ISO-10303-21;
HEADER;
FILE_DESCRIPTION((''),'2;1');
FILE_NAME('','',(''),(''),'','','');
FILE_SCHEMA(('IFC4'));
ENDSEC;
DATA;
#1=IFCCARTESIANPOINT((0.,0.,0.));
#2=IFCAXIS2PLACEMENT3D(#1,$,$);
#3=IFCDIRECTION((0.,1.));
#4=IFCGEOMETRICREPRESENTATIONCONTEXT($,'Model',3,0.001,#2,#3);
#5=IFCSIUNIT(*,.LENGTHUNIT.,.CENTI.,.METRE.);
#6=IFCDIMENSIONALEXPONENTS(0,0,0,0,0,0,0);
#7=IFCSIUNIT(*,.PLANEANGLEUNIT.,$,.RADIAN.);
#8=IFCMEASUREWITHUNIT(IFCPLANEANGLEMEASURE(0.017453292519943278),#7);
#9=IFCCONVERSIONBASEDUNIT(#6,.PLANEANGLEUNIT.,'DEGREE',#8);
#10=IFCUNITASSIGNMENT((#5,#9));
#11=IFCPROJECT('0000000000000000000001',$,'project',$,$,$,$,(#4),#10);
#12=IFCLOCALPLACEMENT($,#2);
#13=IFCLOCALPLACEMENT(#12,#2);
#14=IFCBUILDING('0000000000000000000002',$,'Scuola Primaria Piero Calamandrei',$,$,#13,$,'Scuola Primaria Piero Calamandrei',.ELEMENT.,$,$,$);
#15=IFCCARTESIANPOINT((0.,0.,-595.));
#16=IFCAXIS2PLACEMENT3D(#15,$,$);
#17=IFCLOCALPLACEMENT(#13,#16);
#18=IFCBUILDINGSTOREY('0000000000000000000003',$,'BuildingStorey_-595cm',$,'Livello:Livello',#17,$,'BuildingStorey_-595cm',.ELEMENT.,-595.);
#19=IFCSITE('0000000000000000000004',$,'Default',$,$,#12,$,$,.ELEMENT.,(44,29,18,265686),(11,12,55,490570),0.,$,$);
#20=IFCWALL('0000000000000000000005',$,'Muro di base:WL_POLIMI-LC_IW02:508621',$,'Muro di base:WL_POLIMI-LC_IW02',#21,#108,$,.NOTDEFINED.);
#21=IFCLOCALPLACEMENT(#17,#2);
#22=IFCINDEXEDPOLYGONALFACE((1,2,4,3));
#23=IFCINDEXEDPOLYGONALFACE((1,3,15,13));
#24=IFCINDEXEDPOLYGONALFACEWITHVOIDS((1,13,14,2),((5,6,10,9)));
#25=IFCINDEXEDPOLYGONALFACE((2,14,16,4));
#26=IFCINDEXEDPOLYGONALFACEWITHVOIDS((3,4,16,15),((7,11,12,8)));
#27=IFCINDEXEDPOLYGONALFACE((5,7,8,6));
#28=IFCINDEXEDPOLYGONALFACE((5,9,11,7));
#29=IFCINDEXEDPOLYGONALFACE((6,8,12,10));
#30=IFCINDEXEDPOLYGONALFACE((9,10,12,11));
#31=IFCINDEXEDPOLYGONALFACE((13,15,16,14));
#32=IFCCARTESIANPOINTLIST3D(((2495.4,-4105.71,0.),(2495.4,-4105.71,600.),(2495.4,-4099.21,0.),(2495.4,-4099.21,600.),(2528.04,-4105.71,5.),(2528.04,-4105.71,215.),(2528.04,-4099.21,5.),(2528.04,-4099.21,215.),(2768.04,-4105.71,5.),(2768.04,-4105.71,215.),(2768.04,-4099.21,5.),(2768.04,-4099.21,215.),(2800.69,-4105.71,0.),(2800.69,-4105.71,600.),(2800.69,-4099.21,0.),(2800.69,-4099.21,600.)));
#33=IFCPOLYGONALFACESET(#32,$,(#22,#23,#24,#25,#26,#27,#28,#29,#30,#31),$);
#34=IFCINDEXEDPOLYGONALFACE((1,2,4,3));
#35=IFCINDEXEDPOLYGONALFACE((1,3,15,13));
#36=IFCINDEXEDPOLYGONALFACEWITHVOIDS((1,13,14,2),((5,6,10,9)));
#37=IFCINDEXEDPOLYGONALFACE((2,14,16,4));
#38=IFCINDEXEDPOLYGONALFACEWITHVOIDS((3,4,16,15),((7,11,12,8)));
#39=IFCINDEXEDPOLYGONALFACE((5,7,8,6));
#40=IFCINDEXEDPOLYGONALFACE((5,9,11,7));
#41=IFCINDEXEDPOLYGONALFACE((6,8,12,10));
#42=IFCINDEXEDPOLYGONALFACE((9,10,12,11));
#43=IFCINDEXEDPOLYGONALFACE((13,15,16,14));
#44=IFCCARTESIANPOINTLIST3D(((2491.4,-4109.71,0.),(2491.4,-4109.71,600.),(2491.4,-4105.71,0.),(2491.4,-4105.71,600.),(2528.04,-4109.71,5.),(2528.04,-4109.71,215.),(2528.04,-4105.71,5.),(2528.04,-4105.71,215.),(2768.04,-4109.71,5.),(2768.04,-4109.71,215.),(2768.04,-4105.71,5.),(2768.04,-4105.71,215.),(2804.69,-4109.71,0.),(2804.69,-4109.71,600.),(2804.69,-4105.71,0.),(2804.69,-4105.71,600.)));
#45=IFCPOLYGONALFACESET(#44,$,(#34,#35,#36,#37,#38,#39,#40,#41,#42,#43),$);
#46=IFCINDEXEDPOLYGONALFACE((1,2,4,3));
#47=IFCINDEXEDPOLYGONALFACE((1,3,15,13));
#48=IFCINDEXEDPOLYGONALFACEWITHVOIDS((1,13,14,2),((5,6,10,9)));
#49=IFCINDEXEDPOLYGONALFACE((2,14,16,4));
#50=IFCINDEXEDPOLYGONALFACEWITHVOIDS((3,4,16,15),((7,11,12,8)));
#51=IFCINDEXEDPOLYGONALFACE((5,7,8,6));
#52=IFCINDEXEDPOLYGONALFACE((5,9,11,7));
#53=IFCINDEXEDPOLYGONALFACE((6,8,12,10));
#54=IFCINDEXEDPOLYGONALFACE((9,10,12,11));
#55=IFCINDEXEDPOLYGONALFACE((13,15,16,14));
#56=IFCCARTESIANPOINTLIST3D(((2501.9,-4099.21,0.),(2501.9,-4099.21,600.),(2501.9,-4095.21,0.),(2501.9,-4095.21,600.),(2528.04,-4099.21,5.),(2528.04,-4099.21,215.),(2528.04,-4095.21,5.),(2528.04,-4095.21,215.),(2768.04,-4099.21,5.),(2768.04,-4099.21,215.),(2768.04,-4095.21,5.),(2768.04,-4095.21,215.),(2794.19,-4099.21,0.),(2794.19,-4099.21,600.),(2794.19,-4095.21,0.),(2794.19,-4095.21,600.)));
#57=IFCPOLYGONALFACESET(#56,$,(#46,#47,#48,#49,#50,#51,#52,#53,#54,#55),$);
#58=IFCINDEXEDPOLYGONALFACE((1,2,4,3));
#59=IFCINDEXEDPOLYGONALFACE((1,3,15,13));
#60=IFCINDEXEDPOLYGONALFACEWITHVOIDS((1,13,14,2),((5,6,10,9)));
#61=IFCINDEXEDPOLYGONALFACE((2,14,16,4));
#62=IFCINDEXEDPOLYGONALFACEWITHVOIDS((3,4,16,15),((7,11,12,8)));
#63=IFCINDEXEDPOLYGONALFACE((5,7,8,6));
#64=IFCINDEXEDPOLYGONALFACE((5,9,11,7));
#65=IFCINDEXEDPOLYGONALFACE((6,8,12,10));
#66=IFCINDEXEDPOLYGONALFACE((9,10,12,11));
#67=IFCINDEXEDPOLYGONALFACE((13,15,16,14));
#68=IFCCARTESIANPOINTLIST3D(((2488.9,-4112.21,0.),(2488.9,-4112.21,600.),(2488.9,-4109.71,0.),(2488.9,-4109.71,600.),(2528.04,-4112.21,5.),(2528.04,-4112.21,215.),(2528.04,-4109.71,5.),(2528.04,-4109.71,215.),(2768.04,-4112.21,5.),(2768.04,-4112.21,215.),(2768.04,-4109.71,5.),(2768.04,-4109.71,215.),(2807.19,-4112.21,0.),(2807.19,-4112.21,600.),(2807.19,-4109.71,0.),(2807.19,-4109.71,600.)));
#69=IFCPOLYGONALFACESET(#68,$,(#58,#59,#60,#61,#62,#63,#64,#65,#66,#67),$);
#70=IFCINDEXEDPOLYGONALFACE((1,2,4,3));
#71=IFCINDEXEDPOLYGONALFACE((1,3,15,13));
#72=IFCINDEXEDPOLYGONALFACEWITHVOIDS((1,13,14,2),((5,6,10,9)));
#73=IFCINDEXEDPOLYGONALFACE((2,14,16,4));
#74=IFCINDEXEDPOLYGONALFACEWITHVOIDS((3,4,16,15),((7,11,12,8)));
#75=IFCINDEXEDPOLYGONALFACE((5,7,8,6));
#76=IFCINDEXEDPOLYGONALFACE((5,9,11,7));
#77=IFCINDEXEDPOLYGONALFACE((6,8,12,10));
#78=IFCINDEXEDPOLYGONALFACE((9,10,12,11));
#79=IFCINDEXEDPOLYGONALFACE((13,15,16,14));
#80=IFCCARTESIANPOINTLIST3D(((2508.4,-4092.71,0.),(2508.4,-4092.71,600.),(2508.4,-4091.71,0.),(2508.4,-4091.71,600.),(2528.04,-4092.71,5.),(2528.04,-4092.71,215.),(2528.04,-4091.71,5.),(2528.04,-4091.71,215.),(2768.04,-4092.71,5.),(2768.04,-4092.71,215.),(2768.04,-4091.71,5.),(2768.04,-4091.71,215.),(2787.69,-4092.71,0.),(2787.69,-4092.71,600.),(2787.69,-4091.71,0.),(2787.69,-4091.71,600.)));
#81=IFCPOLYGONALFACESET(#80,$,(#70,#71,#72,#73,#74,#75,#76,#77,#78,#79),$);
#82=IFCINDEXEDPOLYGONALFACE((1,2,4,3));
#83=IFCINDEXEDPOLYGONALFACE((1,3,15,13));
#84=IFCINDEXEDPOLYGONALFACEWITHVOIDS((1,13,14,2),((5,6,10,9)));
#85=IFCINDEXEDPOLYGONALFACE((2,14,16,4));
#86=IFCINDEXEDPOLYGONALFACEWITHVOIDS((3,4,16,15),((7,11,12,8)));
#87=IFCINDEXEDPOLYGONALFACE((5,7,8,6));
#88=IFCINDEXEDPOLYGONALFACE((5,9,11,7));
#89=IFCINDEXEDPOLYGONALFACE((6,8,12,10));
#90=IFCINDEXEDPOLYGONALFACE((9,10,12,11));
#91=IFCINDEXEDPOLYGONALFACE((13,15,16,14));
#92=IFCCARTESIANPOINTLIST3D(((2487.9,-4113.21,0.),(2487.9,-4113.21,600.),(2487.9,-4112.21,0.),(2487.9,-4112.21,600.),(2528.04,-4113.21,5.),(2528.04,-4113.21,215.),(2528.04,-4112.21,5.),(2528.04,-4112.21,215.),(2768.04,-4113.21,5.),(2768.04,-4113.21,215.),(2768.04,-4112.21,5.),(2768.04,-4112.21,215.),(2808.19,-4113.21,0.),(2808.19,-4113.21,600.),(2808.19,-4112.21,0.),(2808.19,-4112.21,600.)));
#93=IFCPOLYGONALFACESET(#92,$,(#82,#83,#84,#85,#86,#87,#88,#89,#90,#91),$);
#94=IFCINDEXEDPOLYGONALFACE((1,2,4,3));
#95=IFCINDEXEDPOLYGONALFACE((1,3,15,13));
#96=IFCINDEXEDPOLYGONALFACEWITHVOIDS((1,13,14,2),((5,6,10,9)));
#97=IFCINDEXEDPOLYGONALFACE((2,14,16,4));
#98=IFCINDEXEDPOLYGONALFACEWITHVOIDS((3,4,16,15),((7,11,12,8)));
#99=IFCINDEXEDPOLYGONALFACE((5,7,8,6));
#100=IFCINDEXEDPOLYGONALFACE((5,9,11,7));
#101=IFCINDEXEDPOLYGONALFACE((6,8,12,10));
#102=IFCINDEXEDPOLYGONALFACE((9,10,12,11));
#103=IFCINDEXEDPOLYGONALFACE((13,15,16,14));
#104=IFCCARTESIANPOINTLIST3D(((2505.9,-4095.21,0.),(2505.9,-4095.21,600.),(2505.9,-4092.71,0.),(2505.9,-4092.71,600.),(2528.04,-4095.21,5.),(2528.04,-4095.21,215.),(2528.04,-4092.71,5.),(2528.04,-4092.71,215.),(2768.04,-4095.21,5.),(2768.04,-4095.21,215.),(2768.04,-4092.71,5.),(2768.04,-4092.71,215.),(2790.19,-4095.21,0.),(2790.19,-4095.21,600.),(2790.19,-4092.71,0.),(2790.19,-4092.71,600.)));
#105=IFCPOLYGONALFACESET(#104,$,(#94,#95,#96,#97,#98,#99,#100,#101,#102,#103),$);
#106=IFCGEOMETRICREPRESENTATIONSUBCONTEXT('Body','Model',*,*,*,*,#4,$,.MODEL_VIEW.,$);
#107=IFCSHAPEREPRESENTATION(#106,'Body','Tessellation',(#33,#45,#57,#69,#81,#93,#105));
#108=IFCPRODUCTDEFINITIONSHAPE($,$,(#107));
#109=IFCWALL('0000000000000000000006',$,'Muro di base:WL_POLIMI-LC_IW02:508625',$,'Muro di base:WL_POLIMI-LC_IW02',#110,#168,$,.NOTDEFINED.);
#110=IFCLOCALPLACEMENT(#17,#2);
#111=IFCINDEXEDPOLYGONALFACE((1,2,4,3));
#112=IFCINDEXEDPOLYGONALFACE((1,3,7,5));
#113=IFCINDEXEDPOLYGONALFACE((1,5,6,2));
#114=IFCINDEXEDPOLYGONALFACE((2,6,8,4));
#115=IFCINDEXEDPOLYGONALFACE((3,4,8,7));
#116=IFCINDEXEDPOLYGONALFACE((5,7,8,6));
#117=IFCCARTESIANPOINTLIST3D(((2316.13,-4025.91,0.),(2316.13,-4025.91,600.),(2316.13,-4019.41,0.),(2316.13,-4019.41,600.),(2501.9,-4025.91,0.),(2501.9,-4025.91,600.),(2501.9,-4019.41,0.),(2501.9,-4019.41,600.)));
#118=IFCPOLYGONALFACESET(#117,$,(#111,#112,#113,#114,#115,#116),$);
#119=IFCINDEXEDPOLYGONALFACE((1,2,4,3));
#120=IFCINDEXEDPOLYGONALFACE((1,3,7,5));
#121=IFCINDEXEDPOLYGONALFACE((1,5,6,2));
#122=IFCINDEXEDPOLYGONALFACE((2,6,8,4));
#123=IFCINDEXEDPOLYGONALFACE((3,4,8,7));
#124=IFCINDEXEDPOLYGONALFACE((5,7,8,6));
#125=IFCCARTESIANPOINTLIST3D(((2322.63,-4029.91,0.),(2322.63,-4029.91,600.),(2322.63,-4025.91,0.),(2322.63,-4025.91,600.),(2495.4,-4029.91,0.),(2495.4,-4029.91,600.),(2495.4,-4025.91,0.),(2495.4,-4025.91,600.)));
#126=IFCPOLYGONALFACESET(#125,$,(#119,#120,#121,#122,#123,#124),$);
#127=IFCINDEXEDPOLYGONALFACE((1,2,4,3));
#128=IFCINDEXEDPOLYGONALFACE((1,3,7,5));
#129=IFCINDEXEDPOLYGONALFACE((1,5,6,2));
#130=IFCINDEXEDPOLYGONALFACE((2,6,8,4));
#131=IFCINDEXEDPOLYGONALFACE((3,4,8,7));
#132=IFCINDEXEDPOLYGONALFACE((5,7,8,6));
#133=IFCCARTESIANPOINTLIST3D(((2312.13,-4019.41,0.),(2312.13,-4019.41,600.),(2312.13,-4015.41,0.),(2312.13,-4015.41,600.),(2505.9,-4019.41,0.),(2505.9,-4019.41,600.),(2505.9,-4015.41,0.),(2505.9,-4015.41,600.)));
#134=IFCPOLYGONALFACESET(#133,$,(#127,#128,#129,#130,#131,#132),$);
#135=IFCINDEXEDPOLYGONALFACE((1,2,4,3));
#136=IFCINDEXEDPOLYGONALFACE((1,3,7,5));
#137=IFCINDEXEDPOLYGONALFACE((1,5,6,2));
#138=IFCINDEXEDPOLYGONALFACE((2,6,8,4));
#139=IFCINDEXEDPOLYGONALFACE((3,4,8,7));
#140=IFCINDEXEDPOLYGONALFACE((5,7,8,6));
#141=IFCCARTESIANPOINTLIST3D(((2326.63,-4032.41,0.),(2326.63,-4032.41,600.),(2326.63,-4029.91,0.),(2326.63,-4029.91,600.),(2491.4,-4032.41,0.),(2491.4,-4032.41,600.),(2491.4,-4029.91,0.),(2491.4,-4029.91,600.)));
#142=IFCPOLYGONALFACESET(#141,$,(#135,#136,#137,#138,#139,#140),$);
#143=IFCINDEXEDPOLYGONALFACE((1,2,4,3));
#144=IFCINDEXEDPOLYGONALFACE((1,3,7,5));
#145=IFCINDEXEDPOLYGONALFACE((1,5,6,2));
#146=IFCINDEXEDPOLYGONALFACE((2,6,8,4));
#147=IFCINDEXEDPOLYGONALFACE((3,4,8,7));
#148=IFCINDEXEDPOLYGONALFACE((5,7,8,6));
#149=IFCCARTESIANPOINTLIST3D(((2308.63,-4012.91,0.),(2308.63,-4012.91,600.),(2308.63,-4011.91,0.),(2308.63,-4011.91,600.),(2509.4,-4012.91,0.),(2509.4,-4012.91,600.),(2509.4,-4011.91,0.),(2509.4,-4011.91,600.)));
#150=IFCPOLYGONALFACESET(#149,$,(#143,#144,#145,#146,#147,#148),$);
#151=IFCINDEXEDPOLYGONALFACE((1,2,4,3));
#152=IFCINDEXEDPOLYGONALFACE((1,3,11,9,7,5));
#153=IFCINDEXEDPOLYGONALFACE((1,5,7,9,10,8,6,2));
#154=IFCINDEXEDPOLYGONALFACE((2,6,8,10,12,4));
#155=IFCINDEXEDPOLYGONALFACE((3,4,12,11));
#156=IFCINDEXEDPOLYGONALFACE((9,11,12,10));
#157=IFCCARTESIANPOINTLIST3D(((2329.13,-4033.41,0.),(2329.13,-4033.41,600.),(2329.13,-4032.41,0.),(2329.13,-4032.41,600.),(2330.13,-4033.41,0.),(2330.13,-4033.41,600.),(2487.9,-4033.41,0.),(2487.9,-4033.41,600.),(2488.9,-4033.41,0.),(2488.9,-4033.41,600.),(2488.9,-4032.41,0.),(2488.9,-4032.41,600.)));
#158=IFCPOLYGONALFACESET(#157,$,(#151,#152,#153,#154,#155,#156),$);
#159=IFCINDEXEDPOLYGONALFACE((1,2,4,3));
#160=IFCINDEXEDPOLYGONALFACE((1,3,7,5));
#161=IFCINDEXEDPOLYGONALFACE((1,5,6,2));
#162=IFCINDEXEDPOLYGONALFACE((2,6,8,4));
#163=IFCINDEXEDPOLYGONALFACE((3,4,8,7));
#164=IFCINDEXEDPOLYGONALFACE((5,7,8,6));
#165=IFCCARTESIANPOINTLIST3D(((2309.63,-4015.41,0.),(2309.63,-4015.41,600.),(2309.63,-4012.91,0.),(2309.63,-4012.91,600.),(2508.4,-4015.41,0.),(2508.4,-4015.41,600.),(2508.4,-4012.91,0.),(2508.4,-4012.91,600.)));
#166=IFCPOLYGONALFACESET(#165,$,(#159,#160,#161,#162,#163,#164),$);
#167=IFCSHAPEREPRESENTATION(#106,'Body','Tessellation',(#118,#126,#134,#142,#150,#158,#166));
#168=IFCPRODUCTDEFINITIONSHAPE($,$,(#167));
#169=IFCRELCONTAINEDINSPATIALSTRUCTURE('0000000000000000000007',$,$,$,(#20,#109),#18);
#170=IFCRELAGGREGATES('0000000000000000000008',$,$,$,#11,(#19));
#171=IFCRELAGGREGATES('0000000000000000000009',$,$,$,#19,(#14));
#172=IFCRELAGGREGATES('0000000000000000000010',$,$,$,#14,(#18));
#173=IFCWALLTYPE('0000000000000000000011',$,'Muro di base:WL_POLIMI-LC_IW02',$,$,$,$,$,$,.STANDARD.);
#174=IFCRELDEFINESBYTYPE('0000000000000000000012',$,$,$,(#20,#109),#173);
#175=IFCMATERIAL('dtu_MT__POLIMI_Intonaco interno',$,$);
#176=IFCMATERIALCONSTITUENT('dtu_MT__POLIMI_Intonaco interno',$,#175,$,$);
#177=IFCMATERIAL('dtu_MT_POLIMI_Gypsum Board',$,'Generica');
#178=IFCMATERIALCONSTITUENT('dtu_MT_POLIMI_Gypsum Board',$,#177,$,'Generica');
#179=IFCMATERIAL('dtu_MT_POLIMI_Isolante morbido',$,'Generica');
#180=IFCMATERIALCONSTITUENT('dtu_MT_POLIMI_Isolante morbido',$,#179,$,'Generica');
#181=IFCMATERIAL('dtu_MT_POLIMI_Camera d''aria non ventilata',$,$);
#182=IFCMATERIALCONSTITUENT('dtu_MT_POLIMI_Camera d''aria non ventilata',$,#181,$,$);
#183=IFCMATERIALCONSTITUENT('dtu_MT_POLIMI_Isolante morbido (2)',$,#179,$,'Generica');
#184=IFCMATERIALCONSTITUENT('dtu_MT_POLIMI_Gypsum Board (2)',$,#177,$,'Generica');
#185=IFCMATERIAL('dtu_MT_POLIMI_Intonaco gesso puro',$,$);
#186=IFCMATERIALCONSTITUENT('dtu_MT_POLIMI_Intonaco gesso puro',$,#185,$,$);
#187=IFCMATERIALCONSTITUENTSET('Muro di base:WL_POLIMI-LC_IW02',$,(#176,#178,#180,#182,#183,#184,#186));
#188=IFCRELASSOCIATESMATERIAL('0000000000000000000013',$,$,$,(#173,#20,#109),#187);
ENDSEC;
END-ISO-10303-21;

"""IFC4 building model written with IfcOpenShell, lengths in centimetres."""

from ifc_helpers import new_model, entity, si_unit, converted_unit, direction, frame, origin, place, context, subcontext, project, spatial, indexed_curve, outline, extrude, material, constituent, constituent_set, type_object, element, save


model = new_model("IFC4")

# Units and contexts
model_context = context("Model", 3, precision=0.001, world=origin(), true_north=direction((0.0, 1.0)))
body_context = subcontext(model_context, "Body", "Model", "MODEL_VIEW")
ifc_project = project(units=[si_unit("LENGTHUNIT", "METRE", prefix="CENTI"), converted_unit("PLANEANGLEUNIT", "DEGREE", entity("IfcPlaneAngleMeasure", 0.017453292519943278), si_unit("PLANEANGLEUNIT", "RADIAN"), dimensions=[0, 0, 0, 0, 0, 0, 0])], contexts=[model_context])

# Site, building, storey
site_placement = place(None, origin())
site = spatial("IfcSite", under=ifc_project, at=site_placement, Name="Default", CompositionType="ELEMENT", RefLatitude=(44, 29, 18, 265686), RefLongitude=(11, 12, 55, 490570), RefElevation=0.0)
building_placement = place(site_placement, origin())
building = spatial("IfcBuilding", under=site, at=building_placement, Name="Scuola Primaria Piero Calamandrei", LongName="Scuola Primaria Piero Calamandrei", CompositionType="ELEMENT")
storey_placement = place(building_placement, frame((0.0, 0.0, -595.0)))
storey = spatial("IfcBuildingStorey", under=building, at=storey_placement, Name="BuildingStorey_-595cm", ObjectType="Livello:Livello", LongName="BuildingStorey_-595cm", CompositionType="ELEMENT", Elevation=-595.0)

# Shared definitions
ifc_material_1 = material(Name="dtu_MT__POLIMI_Intonaco interno")
ifc_constituent_1 = constituent(ifc_material_1, Name="dtu_MT__POLIMI_Intonaco interno")
ifc_material_2 = material(Name="dtu_MT_POLIMI_Gypsum Board", Category="Generica")
ifc_constituent_2 = constituent(ifc_material_2, Name="dtu_MT_POLIMI_Gypsum Board", Category="Generica")
ifc_material_3 = material(Name="dtu_MT_POLIMI_Isolante morbido", Category="Generica")
ifc_constituent_3 = constituent(ifc_material_3, Name="dtu_MT_POLIMI_Isolante morbido", Category="Generica")
ifc_material_4 = material(Name="dtu_MT_POLIMI_Camera d'aria non ventilata")
ifc_constituent_4 = constituent(ifc_material_4, Name="dtu_MT_POLIMI_Camera d'aria non ventilata")
ifc_constituent_5 = constituent(ifc_material_3, Name="dtu_MT_POLIMI_Isolante morbido (2)", Category="Generica")
ifc_constituent_6 = constituent(ifc_material_2, Name="dtu_MT_POLIMI_Gypsum Board (2)", Category="Generica")
ifc_material_5 = material(Name="dtu_MT_POLIMI_Intonaco gesso puro")
ifc_constituent_7 = constituent(ifc_material_5, Name="dtu_MT_POLIMI_Intonaco gesso puro")
ifc_constituent_set_1 = constituent_set(constituents=[ifc_constituent_1, ifc_constituent_2, ifc_constituent_3, ifc_constituent_4, ifc_constituent_5, ifc_constituent_6, ifc_constituent_7], Name="Muro di base:WL_POLIMI-LC_IW02")
wall_type_1 = type_object("IfcWallType", Name="Muro di base:WL_POLIMI-LC_IW02", PredefinedType="STANDARD", material=ifc_constituent_set_1)

# Wall, opening
wall_1_placement = place(storey_placement, frame((2808.19, -4102.46, 0.0), z_axis=(0.0, 0.0, 1.0), x_axis=(-1.0, 0.0, 0.0)))
wall_1 = element("IfcWall", 1, at=wall_1_placement, inside=storey, type_object=wall_type_1, material=ifc_constituent_set_1, Name="Muro di base:WL_POLIMI-LC_IW02:508621", ObjectType="Muro di base:WL_POLIMI-LC_IW02", PredefinedType="NOTDEFINED", context=body_context, shape_type="SweptSolid", body=[
    extrude(outline(indexed_curve([(-300.0, -152.64), (300.0, -152.64), (300.0, 152.64), (-300.0, 152.64), (-300.0, -152.64)], self_intersect=False), holes=[indexed_curve([(-85.0, 120.0), (-85.0, -120.0), (-295.0, -120.0), (-295.0, 120.0), (-85.0, 120.0)], self_intersect=False)]), frame((160.14, 3.25, 300.0), z_axis=(0.0, -1.0, 0.0), x_axis=(0.0, 0.0, 1.0)), (0.0, 0.0, 1.0), 6.5),
    extrude(outline(indexed_curve([(-300.0, -156.64), (300.0, -156.64), (300.0, 156.64), (-300.0, 156.64), (-300.0, -156.64)], self_intersect=False), holes=[indexed_curve([(-85.0, 120.0), (-85.0, -120.0), (-295.0, -120.0), (-295.0, 120.0), (-85.0, 120.0)], self_intersect=False)]), frame((160.14, 7.25, 300.0), z_axis=(0.0, -1.0, 0.0), x_axis=(0.0, 0.0, 1.0)), (0.0, 0.0, 1.0), 4.0),
    extrude(outline(indexed_curve([(-300.0, -146.14), (300.0, -146.14), (300.0, 146.14), (-300.0, 146.14), (-300.0, -146.14)], self_intersect=False), holes=[indexed_curve([(-85.0, 120.0), (-85.0, -120.0), (-295.0, -120.0), (-295.0, 120.0), (-85.0, 120.0)], self_intersect=False)]), frame((160.14, -3.25, 300.0), z_axis=(0.0, -1.0, 0.0), x_axis=(0.0, 0.0, 1.0)), (0.0, 0.0, 1.0), 4.0),
    extrude(outline(indexed_curve([(-300.0, -159.14), (300.0, -159.14), (300.0, 159.14), (-300.0, 159.14), (-300.0, -159.14)], self_intersect=False), holes=[indexed_curve([(-85.0, 120.0), (-85.0, -120.0), (-295.0, -120.0), (-295.0, 120.0), (-85.0, 120.0)], self_intersect=False)]), frame((160.14, 9.75, 300.0), z_axis=(0.0, -1.0, 0.0), x_axis=(0.0, 0.0, 1.0)), (0.0, 0.0, 1.0), 2.5),
    extrude(outline(indexed_curve([(-300.0, -139.64), (300.0, -139.64), (300.0, 139.64), (-300.0, 139.64), (-300.0, -139.64)], self_intersect=False), holes=[indexed_curve([(-85.0, 120.0), (-85.0, -120.0), (-295.0, -120.0), (-295.0, 120.0), (-85.0, 120.0)], self_intersect=False)]), frame((160.14, -9.75, 300.0), z_axis=(0.0, -1.0, 0.0), x_axis=(0.0, 0.0, 1.0)), (0.0, 0.0, 1.0), 1.0),
    extrude(outline(indexed_curve([(-160.14, -300.0), (160.14, -300.0), (160.14, 300.0), (-160.14, 300.0), (-160.14, -300.0)], self_intersect=False), holes=[indexed_curve([(-120.0, -85.0), (120.0, -85.0), (120.0, -295.0), (-120.0, -295.0), (-120.0, -85.0)], self_intersect=False)]), frame((160.14, 10.75, 300.0), z_axis=(0.0, -1.0, 0.0), x_axis=(1.0, 0.0, 0.0)), (0.0, 0.0, 1.0), 1.0),
    extrude(outline(indexed_curve([(-300.0, -142.14), (300.0, -142.14), (300.0, 142.14), (-300.0, 142.14), (-300.0, -142.14)], self_intersect=False), holes=[indexed_curve([(-85.0, 120.0), (-85.0, -120.0), (-295.0, -120.0), (-295.0, 120.0), (-85.0, 120.0)], self_intersect=False)]), frame((160.14, -7.25, 300.0), z_axis=(0.0, -1.0, 0.0), x_axis=(0.0, 0.0, 1.0)), (0.0, 0.0, 1.0), 2.5),
])
opening_1_placement = place(wall_1_placement, frame((280.14, 10.75, 5.0)))
element("IfcOpeningElement", 2, at=opening_1_placement, cuts=wall_1, PredefinedType="OPENING", context=body_context, shape_type="SweptSolid", body=[
    extrude(outline(indexed_curve([(210.0, 240.0), (0.0, 240.0), (0.0, 0.0), (210.0, 0.0), (210.0, 240.0)], self_intersect=False)), frame((0.0, 0.0, 0.0), z_axis=(0.0, -1.0, 0.0), x_axis=(0.0, 0.0, 1.0)), (0.0, 0.0, 1.0), 21.5),
])

# Wall
wall_2_placement = place(storey_placement, frame((2509.4, -4022.66, 0.0), z_axis=(0.0, 0.0, 1.0), x_axis=(-1.0, 0.0, 0.0)))
element("IfcWall", 3, at=wall_2_placement, inside=storey, type_object=wall_type_1, material=ifc_constituent_set_1, Name="Muro di base:WL_POLIMI-LC_IW02:508625", ObjectType="Muro di base:WL_POLIMI-LC_IW02", PredefinedType="NOTDEFINED", context=body_context, shape_type="SweptSolid", body=[
    extrude(outline(indexed_curve([(-92.89, -3.25), (92.89, -3.25), (92.89, 3.25), (-92.89, 3.25), (-92.89, -3.25)], self_intersect=False)), frame((100.39, 0.0, 0.0)), (0.0, 0.0, 1.0), 600.0),
    extrude(outline(indexed_curve([(-86.39, -2.0), (86.39, -2.0), (86.39, 2.0), (-86.39, 2.0), (-86.39, -2.0)], self_intersect=False)), frame((100.39, 5.25, 0.0)), (0.0, 0.0, 1.0), 600.0),
    extrude(outline(indexed_curve([(-96.89, -2.0), (96.89, -2.0), (96.89, 2.0), (-96.89, 2.0), (-96.89, -2.0)], self_intersect=False)), frame((100.39, -5.25, 0.0)), (0.0, 0.0, 1.0), 600.0),
    extrude(outline(indexed_curve([(-82.39, -1.25), (82.39, -1.25), (82.39, 1.25), (-82.39, 1.25), (-82.39, -1.25)], self_intersect=False)), frame((100.39, 8.5, 0.0)), (0.0, 0.0, 1.0), 600.0),
    extrude(outline(indexed_curve([(-0.5, -100.39), (0.5, -100.39), (0.5, 100.39), (-0.5, 100.39), (-0.5, -100.39)], self_intersect=False)), frame((100.39, -10.25, 0.0), z_axis=(0.0, 0.0, 1.0), x_axis=(0.0, 1.0, 0.0)), (0.0, 0.0, 1.0), 600.0),
    extrude(outline(indexed_curve([(-78.89, -0.33), (78.89, -0.33), (79.89, -0.33), (79.89, 0.67), (-79.89, 0.67), (-79.89, -0.33), (-78.89, -0.33)], self_intersect=False)), frame((100.39, 10.42, 0.0), z_axis=(0.0, 0.0, 1.0), x_axis=(-1.0, 0.0, 0.0)), (0.0, 0.0, 1.0), 600.0),
    extrude(outline(indexed_curve([(-99.39, -1.25), (99.39, -1.25), (99.39, 1.25), (-99.39, 1.25), (-99.39, -1.25)], self_intersect=False)), frame((100.39, -8.5, 0.0)), (0.0, 0.0, 1.0), 600.0),
])

save(model, "model.ifc")
